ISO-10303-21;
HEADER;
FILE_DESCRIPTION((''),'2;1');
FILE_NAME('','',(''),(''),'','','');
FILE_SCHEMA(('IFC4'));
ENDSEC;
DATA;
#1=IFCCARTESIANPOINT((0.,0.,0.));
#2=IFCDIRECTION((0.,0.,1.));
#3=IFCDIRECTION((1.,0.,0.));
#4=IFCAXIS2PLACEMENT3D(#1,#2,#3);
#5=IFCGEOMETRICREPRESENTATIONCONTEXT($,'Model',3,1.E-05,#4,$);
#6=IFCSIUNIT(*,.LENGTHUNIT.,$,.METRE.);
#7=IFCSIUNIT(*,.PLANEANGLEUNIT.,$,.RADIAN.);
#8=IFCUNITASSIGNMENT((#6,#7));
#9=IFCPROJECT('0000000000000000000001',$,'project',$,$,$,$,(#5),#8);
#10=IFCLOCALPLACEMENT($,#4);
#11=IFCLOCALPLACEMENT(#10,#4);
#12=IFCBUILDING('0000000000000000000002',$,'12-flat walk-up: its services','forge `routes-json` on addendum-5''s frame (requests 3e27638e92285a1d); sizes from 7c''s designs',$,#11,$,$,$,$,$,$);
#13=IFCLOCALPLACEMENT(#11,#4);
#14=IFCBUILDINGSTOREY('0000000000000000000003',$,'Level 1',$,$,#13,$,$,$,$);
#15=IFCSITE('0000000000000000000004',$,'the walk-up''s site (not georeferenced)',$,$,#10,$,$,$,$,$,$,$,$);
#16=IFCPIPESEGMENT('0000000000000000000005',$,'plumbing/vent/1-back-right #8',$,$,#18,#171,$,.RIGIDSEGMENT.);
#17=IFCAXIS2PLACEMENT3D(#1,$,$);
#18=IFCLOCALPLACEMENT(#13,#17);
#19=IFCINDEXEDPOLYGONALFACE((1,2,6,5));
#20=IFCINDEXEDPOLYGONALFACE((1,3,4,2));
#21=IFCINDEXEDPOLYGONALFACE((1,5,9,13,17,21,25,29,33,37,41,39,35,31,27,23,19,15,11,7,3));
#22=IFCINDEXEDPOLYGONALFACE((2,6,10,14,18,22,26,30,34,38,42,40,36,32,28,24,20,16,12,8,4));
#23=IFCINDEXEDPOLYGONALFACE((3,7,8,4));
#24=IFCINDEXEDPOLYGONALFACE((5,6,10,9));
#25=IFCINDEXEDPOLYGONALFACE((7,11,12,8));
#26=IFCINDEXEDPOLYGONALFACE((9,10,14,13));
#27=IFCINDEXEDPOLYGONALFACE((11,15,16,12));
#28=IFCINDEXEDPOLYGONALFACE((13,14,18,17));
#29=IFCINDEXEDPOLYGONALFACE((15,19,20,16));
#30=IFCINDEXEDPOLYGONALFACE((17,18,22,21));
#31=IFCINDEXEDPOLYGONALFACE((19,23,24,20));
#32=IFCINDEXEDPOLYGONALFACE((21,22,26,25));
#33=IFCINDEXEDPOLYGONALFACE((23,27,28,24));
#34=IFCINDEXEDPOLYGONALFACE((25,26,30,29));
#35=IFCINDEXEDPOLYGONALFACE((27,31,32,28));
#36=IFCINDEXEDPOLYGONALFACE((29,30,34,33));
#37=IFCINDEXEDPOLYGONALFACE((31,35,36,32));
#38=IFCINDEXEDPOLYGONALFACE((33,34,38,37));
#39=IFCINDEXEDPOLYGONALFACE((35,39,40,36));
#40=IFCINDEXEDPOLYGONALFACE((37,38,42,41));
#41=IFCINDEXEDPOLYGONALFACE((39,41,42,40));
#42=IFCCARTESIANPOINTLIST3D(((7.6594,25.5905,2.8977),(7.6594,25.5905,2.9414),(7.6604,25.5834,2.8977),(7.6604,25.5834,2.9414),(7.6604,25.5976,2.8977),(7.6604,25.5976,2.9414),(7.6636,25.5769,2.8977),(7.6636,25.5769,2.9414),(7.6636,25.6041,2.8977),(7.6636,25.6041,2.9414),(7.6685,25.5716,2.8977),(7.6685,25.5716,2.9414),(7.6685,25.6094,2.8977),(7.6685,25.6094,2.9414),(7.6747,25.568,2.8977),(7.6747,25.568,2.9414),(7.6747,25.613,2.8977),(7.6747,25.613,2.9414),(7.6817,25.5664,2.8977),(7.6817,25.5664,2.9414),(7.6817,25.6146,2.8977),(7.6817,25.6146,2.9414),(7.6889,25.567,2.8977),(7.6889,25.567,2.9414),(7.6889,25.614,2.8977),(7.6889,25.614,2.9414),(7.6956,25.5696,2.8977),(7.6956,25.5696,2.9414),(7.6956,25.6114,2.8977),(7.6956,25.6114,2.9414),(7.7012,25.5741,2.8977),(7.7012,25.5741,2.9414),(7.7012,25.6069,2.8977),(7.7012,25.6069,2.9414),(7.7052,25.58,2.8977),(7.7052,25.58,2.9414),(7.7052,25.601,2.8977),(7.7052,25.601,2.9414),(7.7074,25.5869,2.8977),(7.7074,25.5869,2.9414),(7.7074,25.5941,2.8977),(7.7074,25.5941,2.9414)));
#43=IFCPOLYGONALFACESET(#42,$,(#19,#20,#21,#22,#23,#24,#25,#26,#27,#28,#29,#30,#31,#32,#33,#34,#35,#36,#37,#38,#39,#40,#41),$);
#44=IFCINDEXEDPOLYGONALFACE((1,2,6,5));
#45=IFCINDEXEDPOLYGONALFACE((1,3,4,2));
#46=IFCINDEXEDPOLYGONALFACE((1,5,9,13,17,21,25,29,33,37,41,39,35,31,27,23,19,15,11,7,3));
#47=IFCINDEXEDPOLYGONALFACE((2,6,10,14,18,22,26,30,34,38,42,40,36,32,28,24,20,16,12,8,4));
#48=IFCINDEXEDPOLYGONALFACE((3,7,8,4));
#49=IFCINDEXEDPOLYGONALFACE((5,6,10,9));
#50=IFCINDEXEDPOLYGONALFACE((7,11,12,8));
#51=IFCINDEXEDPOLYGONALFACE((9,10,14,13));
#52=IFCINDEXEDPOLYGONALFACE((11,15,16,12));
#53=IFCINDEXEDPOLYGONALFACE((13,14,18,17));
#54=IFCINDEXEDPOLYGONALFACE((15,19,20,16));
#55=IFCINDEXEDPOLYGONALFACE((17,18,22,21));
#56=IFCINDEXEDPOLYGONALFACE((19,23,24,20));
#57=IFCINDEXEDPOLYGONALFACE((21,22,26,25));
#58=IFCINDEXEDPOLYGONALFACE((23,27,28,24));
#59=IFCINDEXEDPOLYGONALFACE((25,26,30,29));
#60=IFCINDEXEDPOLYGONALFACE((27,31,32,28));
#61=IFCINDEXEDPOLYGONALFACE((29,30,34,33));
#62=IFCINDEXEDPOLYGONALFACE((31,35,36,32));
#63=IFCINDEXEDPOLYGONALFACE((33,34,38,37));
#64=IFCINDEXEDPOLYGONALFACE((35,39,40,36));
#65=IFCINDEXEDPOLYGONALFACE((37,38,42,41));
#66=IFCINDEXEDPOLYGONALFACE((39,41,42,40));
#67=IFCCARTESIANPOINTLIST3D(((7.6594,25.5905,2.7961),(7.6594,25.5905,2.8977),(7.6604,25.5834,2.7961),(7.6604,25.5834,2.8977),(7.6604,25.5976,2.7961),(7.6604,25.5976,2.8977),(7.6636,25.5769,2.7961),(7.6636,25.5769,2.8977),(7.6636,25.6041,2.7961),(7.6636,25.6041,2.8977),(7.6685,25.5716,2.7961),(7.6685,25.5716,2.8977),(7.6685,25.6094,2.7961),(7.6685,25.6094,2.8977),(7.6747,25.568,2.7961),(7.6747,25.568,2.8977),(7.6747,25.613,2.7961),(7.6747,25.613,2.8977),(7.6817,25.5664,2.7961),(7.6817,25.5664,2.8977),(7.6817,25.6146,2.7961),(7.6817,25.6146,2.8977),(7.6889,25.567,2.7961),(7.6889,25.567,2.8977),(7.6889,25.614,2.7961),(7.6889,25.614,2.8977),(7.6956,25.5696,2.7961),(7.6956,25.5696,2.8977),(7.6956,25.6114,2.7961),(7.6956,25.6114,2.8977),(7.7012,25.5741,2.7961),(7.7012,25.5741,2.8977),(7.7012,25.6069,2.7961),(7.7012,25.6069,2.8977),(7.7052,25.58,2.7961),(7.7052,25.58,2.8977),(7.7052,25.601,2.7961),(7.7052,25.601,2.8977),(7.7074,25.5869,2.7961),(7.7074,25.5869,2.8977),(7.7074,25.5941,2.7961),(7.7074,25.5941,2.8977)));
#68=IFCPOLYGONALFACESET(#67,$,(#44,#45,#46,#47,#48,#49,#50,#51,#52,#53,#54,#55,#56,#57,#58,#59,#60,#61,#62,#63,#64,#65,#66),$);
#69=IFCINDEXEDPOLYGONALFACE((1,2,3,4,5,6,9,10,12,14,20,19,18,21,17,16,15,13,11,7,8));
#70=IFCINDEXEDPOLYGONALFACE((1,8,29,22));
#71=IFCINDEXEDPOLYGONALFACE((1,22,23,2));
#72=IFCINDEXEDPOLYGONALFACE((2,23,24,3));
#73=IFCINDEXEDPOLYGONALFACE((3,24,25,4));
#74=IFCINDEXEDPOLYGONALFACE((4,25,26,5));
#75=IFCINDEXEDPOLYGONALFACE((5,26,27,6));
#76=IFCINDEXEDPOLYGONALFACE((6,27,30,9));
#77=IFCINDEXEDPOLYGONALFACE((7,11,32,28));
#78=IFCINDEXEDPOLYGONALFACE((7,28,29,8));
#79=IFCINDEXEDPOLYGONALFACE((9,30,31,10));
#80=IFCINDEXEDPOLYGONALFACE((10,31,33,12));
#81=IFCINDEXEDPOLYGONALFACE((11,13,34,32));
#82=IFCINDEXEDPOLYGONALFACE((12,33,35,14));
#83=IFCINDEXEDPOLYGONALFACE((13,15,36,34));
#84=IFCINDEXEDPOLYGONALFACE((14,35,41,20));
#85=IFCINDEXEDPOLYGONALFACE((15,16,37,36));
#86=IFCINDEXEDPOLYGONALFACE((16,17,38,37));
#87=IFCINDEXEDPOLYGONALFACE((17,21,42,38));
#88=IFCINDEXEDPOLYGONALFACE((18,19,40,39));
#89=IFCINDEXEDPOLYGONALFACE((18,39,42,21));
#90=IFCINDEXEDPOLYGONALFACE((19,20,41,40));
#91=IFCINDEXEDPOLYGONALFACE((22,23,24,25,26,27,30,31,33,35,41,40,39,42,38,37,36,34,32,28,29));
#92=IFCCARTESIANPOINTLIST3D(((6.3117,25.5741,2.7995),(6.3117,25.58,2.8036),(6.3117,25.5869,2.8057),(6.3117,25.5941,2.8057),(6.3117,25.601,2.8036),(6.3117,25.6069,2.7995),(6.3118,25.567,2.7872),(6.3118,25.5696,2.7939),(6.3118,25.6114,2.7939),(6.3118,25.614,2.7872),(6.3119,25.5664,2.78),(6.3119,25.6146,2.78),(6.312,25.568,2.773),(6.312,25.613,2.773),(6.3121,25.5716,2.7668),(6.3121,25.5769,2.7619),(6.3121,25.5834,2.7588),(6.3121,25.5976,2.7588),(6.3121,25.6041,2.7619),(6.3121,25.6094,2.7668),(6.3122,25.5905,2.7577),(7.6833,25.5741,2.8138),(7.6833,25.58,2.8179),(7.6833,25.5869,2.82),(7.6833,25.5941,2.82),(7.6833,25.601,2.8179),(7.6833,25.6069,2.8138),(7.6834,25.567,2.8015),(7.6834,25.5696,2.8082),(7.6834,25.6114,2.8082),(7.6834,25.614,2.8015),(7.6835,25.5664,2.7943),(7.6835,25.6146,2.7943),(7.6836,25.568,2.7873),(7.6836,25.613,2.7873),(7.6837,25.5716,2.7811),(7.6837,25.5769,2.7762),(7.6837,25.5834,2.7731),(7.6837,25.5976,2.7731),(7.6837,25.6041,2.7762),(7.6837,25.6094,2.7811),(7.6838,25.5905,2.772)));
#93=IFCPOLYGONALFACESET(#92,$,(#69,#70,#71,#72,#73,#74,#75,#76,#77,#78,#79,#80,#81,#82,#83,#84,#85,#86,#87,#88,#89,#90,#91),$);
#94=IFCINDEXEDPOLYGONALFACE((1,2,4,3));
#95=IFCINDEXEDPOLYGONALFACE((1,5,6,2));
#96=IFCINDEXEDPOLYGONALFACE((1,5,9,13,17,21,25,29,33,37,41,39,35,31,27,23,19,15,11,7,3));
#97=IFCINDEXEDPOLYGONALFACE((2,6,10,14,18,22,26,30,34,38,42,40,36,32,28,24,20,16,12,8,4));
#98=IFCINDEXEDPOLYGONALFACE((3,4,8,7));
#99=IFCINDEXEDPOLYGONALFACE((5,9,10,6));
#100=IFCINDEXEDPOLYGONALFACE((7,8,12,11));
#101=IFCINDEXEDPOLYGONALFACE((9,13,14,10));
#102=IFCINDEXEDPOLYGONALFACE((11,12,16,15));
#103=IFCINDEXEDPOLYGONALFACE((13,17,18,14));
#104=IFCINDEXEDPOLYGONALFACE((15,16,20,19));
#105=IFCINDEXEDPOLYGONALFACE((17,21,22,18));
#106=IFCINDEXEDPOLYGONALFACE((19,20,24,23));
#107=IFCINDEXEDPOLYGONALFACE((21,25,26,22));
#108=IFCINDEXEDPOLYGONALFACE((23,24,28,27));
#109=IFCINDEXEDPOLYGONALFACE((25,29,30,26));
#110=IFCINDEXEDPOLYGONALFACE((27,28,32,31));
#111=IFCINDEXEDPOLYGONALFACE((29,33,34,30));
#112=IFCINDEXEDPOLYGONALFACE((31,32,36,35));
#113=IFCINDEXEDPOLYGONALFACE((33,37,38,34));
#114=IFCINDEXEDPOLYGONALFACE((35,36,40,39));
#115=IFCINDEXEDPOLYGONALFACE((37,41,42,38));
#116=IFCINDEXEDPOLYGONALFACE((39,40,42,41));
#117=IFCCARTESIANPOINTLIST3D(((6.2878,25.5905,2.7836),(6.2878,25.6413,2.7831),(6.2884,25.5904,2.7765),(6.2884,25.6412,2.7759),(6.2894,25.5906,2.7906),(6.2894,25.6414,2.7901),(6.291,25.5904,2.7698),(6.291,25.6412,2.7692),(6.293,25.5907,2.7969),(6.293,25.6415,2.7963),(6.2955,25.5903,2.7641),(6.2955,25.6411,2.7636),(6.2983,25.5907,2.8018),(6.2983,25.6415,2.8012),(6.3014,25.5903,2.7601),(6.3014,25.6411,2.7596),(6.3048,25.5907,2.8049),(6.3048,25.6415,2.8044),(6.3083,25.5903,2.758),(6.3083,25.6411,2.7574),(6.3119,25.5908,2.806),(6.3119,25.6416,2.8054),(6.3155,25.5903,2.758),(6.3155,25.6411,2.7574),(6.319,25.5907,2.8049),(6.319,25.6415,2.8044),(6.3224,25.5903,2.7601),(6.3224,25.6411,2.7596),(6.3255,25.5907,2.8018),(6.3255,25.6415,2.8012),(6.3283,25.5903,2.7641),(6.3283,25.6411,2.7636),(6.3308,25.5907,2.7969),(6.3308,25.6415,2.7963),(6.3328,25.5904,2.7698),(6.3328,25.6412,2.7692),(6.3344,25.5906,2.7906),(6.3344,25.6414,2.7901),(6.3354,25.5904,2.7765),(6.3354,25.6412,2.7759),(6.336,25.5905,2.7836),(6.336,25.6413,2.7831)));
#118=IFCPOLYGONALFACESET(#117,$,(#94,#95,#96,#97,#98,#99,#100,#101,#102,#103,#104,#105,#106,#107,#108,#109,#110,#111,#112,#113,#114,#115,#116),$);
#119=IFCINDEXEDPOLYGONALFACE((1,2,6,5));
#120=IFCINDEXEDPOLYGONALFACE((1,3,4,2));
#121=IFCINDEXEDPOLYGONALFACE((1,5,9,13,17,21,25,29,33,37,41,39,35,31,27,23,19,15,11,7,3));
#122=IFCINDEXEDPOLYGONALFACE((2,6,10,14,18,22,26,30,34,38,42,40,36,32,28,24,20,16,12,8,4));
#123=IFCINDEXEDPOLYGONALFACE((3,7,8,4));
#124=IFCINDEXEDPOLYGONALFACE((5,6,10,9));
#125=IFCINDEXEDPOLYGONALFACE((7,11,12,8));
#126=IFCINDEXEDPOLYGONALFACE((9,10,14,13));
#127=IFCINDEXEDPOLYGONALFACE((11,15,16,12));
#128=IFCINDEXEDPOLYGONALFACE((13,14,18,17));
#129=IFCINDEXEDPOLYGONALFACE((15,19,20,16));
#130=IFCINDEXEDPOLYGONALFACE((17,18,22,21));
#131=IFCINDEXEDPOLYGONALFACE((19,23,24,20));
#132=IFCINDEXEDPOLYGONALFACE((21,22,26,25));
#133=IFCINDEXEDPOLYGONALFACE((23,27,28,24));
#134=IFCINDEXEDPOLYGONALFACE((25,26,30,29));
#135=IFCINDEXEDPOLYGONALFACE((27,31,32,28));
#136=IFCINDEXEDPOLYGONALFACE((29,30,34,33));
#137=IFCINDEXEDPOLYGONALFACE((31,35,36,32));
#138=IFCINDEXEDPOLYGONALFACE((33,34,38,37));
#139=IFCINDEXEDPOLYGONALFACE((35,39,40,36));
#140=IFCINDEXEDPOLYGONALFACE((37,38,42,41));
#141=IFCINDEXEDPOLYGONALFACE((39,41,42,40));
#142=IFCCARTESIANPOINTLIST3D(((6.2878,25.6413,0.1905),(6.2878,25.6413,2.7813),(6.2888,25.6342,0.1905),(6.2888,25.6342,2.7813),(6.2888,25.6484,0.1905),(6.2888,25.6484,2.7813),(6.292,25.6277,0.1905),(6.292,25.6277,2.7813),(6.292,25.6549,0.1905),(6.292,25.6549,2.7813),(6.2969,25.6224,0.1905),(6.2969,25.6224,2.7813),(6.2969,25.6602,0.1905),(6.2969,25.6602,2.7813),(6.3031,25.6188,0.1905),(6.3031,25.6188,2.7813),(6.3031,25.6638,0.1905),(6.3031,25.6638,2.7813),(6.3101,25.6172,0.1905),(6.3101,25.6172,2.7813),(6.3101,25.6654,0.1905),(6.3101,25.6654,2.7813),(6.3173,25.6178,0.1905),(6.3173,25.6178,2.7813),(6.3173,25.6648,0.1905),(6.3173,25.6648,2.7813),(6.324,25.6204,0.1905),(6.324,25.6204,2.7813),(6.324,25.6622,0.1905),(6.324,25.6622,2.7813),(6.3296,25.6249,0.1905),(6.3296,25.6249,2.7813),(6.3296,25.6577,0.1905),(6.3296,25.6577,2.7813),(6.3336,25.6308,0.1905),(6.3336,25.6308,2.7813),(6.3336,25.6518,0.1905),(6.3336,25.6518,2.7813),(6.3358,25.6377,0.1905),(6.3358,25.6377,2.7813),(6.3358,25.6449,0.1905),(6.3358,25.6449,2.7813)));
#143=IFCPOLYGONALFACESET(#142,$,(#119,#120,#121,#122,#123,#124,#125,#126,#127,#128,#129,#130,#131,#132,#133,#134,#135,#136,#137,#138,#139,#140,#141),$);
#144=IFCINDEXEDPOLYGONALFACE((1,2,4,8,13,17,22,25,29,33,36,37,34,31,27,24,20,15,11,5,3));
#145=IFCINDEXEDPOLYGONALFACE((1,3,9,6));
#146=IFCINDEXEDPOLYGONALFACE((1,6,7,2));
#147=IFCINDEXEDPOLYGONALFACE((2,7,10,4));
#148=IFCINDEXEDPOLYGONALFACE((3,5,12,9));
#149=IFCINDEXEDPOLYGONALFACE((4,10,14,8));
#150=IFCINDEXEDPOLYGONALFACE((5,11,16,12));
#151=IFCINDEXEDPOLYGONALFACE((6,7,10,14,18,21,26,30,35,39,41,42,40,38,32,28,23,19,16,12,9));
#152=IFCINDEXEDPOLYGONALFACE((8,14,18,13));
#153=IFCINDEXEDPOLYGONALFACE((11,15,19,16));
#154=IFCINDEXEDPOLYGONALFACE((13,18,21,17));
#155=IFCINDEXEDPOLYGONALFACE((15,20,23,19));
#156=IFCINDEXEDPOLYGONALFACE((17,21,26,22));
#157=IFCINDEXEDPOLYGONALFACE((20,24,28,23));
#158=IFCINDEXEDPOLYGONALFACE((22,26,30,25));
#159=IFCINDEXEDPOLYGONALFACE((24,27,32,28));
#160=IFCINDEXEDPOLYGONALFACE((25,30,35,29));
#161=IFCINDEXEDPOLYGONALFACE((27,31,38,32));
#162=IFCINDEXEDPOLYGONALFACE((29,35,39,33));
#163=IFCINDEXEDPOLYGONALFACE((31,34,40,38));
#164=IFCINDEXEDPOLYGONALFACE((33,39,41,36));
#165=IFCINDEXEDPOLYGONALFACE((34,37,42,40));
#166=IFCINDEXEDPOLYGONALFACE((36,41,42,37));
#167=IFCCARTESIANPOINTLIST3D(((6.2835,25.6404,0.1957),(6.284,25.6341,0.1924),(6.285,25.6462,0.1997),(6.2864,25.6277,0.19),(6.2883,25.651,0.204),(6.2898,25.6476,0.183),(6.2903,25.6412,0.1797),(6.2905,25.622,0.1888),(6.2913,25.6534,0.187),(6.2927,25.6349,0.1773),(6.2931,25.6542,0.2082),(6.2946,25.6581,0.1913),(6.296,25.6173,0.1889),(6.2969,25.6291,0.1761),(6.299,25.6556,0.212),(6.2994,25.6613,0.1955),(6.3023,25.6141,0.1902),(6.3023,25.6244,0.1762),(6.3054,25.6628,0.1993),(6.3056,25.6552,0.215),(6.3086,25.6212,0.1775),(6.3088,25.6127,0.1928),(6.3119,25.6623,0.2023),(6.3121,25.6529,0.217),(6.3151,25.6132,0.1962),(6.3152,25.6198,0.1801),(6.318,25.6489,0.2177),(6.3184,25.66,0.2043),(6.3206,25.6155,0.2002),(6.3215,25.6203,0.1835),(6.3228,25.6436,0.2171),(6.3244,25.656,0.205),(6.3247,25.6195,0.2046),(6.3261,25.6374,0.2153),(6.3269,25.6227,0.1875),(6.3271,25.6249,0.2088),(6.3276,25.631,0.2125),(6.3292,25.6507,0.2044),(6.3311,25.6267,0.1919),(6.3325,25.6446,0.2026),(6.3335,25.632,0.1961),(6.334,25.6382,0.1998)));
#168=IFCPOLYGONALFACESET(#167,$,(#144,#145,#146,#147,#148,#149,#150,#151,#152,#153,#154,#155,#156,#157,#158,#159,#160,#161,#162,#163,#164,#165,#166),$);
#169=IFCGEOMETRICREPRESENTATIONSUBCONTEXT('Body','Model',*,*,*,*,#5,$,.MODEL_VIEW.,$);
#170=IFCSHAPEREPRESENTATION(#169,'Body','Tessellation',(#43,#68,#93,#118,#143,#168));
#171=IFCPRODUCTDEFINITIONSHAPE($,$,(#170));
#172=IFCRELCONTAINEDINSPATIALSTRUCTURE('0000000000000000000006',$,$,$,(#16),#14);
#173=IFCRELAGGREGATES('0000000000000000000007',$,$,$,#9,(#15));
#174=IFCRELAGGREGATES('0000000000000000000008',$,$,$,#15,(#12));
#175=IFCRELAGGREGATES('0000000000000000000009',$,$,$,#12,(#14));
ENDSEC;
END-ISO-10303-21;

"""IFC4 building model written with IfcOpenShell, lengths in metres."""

from ifc_helpers import new_model, entity, si_unit, frame, origin_with_axes, place, context, subcontext, project, spatial, element, save


model = new_model("IFC4")

# Units and contexts
model_context = context("Model", 3, precision=1e-05, world=origin_with_axes())
body_context = subcontext(model_context, "Body", "Model", "MODEL_VIEW")
ifc_project = project(units=[si_unit("LENGTHUNIT", "METRE"), si_unit("PLANEANGLEUNIT", "RADIAN")], contexts=[model_context])

# Site, building, storey
site_placement = place(None, origin_with_axes())
site = spatial("IfcSite", under=ifc_project, at=site_placement, Name="the walk-up's site (not georeferenced)")
building_placement = place(site_placement, origin_with_axes())
building = spatial("IfcBuilding", under=site, at=building_placement, Name="12-flat walk-up: its services", Description="forge `routes-json` on addendum-5's frame (requests 3e27638e92285a1d); sizes from 7c's designs")
storey_placement = place(building_placement, origin_with_axes())
storey = spatial("IfcBuildingStorey", under=building, at=storey_placement, Name="Level 1")

# Pipe segment
pipe_segment_1_placement = place(storey_placement, frame((7.6835, 25.5905, 2.9414), z_axis=(0.0, 0.0, 1.0), x_axis=(1.0, 0.0, 0.0)))
element("IfcPipeSegment", 1, at=pipe_segment_1_placement, inside=storey, Name="plumbing/vent/1-back-right #8", PredefinedType="RIGIDSEGMENT", context=body_context, shape_type="AdvancedSweptSolid", body=[
    entity("IfcSweptDiskSolid", entity("IfcPolyline", [entity("IfcCartesianPoint", [0.0, 0.0, 0.0]), entity("IfcCartesianPoint", [0.0, 0.0, -0.0437])]), 0.0241),
    entity("IfcSweptDiskSolid", entity("IfcPolyline", [entity("IfcCartesianPoint", [0.0, 0.0, -0.0437]), entity("IfcCartesianPoint", [0.0, 0.0, -0.1453])]), 0.0241),
    entity("IfcSweptDiskSolid", entity("IfcPolyline", [entity("IfcCartesianPoint", [0.0, 0.0, -0.1453]), entity("IfcCartesianPoint", [-1.3716, 0.0, -0.1595])]), 0.0241),
    entity("IfcSweptDiskSolid", entity("IfcPolyline", [entity("IfcCartesianPoint", [-1.3716, 0.0, -0.1595]), entity("IfcCartesianPoint", [-1.3716, 0.0508, -0.1601])]), 0.0241),
    entity("IfcSweptDiskSolid", entity("IfcPolyline", [entity("IfcCartesianPoint", [-1.3716, 0.0508, -0.1601]), entity("IfcCartesianPoint", [-1.3716, 0.0508, -2.7509])]), 0.0241),
    entity("IfcSweptDiskSolid", entity("IfcPolyline", [entity("IfcCartesianPoint", [-1.3716, 0.0508, -2.7509]), entity("IfcCartesianPoint", [-1.3779, 0.0437, -2.7382])]), 0.0241),
])

save(model, "model.ifc")
